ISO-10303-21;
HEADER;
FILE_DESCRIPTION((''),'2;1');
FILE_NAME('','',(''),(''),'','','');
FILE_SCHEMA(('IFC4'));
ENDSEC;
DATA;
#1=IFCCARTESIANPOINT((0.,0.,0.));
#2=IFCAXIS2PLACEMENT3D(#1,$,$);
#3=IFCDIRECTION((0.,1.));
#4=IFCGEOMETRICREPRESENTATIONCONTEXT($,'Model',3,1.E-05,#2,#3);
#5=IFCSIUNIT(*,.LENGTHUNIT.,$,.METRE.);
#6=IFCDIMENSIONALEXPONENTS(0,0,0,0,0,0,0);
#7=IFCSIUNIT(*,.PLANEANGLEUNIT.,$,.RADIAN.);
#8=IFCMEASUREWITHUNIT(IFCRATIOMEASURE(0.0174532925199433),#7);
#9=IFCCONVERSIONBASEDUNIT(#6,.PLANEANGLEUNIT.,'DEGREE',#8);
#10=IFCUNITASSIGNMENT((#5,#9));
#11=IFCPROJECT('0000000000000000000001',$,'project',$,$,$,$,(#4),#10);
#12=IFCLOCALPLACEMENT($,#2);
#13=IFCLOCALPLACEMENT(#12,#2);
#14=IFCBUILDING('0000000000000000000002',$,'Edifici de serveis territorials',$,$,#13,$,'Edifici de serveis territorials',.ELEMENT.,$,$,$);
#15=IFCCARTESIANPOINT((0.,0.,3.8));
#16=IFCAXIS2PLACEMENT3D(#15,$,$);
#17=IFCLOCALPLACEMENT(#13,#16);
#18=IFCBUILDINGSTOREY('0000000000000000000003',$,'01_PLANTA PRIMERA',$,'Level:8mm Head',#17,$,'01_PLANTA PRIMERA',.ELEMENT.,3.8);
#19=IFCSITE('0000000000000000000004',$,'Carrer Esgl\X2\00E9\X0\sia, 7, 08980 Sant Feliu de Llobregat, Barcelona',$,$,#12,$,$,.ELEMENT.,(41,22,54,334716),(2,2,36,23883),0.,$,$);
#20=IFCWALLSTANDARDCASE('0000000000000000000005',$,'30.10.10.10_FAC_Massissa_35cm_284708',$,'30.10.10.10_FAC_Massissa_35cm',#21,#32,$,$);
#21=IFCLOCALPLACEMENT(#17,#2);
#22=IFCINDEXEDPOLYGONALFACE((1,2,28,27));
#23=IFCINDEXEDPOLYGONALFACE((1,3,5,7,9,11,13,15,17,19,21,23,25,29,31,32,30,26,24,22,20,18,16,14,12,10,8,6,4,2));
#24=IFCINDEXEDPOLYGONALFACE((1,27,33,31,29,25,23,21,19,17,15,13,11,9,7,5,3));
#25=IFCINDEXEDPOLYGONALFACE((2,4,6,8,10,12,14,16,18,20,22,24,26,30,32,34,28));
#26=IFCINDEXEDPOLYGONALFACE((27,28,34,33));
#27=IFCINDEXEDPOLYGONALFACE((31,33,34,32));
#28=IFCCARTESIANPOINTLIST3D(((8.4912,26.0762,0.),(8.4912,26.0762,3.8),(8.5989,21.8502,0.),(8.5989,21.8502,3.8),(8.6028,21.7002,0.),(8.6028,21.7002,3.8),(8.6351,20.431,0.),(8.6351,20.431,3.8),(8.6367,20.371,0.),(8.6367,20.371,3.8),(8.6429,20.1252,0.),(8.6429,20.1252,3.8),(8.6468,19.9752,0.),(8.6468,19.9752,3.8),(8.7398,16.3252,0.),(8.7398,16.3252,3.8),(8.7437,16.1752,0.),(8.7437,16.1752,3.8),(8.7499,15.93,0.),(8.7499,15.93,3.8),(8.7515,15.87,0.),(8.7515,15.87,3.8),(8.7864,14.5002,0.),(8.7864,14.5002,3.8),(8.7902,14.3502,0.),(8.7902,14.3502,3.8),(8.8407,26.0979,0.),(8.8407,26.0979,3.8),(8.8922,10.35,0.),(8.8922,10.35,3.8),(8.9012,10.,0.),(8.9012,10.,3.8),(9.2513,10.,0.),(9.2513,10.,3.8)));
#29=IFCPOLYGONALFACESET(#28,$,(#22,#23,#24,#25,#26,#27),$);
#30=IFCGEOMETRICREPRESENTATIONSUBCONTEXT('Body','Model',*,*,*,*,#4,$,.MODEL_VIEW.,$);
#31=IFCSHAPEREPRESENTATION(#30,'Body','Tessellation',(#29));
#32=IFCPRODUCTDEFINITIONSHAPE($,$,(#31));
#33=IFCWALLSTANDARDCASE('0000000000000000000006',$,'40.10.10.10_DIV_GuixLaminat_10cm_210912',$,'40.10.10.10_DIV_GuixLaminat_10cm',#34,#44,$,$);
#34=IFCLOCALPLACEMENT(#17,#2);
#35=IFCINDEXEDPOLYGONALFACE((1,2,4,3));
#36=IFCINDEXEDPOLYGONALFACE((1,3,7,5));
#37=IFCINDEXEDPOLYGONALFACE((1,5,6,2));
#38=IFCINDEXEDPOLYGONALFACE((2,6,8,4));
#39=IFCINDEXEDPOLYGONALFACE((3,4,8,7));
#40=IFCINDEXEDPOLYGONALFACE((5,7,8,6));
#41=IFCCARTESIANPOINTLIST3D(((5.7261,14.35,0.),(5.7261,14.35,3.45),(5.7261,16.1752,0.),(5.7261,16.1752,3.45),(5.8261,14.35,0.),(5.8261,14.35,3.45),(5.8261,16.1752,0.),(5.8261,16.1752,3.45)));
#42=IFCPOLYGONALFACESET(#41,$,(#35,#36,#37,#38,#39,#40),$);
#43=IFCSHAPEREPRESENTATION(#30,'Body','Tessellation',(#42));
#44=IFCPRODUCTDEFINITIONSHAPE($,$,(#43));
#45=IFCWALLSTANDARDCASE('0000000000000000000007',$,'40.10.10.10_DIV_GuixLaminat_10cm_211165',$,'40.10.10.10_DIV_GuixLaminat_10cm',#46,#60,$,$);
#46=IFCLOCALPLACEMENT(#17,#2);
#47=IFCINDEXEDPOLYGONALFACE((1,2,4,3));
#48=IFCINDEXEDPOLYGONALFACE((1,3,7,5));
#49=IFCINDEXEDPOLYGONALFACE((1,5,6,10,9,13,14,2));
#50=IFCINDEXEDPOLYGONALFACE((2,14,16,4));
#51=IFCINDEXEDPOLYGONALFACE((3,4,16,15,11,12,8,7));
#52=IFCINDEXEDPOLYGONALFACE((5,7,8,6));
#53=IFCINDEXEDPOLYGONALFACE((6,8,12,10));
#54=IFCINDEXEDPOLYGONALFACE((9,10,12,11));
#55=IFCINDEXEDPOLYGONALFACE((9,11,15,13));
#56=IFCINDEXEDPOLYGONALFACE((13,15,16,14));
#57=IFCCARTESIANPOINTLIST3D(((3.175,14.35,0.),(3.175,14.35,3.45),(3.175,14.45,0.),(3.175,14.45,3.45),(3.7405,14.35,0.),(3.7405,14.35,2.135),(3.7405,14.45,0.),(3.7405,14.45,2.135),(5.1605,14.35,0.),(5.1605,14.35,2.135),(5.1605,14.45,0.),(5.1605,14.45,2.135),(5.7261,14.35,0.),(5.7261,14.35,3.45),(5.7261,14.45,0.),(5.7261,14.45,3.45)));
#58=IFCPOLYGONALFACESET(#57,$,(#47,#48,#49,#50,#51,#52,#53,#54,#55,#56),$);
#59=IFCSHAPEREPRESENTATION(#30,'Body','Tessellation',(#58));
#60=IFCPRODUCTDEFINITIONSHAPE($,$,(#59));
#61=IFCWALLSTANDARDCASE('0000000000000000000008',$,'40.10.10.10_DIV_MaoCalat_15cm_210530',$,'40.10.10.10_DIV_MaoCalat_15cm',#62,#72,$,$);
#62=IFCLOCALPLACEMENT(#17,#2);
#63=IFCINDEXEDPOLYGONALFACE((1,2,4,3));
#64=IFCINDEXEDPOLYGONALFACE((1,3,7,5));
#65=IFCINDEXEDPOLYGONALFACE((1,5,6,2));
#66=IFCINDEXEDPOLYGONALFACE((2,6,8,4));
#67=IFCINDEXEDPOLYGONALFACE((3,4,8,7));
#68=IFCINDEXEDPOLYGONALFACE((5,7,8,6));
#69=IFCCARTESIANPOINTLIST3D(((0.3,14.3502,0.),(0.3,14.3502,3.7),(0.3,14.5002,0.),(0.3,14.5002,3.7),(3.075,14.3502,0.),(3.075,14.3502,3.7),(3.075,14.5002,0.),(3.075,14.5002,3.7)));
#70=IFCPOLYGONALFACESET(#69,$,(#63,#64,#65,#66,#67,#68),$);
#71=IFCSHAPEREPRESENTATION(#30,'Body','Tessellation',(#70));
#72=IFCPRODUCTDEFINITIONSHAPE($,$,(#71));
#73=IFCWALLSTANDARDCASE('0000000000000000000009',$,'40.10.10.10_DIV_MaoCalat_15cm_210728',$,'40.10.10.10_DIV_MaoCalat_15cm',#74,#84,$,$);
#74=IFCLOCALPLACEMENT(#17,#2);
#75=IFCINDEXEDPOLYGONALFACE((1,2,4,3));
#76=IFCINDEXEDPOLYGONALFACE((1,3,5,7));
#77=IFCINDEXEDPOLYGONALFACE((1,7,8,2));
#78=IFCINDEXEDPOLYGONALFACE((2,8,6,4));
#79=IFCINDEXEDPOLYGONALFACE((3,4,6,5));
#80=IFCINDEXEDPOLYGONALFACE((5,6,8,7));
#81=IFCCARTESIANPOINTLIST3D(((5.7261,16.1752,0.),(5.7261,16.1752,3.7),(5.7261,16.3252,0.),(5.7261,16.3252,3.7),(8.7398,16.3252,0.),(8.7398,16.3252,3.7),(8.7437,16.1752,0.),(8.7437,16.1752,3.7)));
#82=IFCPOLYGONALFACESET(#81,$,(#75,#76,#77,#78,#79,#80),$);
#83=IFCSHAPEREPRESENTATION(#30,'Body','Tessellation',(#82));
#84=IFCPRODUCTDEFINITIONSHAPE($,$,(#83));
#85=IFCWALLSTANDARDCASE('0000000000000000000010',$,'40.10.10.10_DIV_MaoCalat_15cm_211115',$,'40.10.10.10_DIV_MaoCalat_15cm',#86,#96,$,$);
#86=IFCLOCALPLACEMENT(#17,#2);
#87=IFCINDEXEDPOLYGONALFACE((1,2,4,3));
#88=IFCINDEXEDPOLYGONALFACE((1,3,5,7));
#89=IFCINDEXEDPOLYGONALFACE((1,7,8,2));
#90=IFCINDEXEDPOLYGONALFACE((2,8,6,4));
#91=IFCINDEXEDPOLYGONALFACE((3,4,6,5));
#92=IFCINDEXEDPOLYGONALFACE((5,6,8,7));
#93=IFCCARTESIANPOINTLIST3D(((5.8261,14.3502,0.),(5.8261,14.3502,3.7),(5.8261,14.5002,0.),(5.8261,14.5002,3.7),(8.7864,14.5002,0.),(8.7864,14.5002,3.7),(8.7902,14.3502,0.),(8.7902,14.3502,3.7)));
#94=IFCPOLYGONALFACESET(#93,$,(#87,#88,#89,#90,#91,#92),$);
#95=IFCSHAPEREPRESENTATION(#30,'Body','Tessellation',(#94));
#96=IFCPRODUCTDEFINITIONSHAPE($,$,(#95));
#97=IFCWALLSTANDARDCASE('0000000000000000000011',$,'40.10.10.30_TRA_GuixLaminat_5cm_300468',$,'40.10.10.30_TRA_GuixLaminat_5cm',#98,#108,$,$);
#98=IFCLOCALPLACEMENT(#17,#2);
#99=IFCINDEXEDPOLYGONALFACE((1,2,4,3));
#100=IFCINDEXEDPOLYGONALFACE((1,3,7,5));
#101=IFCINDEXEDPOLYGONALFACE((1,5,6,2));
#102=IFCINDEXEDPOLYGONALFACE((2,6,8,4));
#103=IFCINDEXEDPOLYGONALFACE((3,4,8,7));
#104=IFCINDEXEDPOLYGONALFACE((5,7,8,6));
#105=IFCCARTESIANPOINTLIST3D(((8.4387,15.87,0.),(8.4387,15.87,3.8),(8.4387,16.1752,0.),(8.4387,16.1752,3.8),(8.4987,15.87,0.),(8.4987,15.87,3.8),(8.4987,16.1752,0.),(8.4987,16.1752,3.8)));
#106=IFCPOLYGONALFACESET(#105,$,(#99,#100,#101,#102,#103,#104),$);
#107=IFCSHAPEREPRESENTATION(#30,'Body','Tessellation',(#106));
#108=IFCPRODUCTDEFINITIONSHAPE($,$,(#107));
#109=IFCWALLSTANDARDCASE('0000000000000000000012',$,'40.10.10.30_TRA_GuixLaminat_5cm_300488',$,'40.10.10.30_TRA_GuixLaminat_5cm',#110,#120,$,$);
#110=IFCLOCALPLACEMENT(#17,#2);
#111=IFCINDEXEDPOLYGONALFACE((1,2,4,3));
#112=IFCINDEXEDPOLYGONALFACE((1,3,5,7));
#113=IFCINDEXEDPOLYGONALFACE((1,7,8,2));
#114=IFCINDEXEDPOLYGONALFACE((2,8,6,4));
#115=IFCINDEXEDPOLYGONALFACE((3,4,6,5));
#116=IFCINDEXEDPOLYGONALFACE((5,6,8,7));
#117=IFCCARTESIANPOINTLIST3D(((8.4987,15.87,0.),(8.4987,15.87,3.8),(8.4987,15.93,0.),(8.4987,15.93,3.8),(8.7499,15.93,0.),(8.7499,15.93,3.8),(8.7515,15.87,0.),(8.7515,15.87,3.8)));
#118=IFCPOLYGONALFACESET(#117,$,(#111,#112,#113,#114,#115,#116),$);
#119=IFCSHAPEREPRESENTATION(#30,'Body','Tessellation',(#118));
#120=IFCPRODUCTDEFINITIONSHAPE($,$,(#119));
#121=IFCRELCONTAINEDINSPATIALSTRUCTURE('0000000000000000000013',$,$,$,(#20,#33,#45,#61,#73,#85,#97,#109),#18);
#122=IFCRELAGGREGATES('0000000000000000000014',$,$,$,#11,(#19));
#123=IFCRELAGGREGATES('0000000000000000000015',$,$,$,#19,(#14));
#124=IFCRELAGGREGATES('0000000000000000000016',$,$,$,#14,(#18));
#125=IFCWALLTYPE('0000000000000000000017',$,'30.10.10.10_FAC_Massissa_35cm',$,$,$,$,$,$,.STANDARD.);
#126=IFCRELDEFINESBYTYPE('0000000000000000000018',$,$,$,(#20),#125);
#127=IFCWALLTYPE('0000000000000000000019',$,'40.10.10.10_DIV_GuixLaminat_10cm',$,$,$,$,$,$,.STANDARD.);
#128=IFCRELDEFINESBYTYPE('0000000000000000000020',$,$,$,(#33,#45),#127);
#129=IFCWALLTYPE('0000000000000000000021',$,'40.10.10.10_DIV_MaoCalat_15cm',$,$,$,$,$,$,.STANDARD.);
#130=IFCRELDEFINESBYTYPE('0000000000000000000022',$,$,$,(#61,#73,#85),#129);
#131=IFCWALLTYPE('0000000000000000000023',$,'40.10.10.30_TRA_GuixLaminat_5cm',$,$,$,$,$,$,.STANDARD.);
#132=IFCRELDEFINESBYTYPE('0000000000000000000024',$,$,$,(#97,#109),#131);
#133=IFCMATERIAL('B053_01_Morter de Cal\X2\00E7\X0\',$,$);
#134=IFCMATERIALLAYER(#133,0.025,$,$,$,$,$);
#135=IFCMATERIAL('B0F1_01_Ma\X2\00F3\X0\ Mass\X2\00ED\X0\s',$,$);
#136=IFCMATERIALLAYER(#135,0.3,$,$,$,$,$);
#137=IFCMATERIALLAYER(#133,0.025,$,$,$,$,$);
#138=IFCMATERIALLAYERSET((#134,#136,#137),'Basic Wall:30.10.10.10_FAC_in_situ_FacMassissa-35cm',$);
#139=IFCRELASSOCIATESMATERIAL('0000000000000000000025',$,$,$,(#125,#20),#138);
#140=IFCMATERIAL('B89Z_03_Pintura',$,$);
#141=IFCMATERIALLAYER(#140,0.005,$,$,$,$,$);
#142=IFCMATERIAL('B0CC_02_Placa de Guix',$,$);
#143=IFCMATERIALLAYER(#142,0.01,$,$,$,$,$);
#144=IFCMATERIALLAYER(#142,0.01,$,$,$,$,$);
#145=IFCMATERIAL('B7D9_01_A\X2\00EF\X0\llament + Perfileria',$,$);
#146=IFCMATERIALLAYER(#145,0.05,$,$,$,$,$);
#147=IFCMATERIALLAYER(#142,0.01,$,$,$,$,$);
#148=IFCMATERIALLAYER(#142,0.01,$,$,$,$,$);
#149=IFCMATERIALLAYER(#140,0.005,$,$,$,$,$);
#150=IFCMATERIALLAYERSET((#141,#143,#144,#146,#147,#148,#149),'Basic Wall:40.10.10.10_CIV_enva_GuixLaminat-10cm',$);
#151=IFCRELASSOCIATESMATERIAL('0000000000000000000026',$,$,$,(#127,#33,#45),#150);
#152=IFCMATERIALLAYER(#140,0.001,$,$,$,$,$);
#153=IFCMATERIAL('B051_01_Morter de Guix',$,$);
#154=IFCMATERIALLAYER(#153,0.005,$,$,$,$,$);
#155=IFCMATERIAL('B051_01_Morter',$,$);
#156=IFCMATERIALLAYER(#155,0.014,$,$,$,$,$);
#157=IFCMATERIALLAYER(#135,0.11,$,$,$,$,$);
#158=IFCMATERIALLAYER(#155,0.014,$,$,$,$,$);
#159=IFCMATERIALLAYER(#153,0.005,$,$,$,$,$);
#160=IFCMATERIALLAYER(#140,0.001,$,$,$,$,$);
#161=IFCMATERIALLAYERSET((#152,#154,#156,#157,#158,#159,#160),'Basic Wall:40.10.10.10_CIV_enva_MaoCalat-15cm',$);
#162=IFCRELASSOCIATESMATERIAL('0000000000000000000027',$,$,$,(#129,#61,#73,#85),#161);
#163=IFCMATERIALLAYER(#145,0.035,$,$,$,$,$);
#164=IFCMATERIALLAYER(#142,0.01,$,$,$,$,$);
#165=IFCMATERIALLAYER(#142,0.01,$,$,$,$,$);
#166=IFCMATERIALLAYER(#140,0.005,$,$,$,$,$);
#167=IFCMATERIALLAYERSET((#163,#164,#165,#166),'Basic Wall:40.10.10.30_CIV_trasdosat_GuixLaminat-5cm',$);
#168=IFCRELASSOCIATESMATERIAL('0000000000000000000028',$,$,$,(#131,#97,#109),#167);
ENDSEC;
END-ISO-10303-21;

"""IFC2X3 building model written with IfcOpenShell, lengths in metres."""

from ifc_helpers import new_model, entity, si_unit, converted_unit, direction, frame, frame_2d, origin, place, context, subcontext, project, spatial, polyline, rectangle, outline, extrude, clip, bounded_halfspace, material, layer, layer_set, layer_usage, type_object, element, save


model = new_model("IFC2X3")

# Units and contexts
model_context = context("Model", 3, precision=1e-05, world=origin(), true_north=direction((0.0, 1.0)))
body_context = subcontext(model_context, "Body", "Model", "MODEL_VIEW")
ifc_project = project(units=[si_unit("LENGTHUNIT", "METRE"), converted_unit("PLANEANGLEUNIT", "DEGREE", entity("IfcRatioMeasure", 0.0174532925199433), si_unit("PLANEANGLEUNIT", "RADIAN"), dimensions=[0, 0, 0, 0, 0, 0, 0])], contexts=[model_context])

# Site, building, storey
site_placement = place(None, origin())
site = spatial("IfcSite", under=ifc_project, at=site_placement, Name="Carrer Església, 7, 08980 Sant Feliu de Llobregat, Barcelona", CompositionType="ELEMENT", RefLatitude=(41, 22, 54, 334716), RefLongitude=(2, 2, 36, 23883), RefElevation=0.0)
building_placement = place(site_placement, origin())
building = spatial("IfcBuilding", under=site, at=building_placement, Name="Edifici de serveis territorials", LongName="Edifici de serveis territorials", CompositionType="ELEMENT")
storey_placement = place(building_placement, frame((0.0, 0.0, 3.8)))
storey = spatial("IfcBuildingStorey", under=building, at=storey_placement, Name="01_PLANTA PRIMERA", ObjectType="Level:8mm Head", LongName="01_PLANTA PRIMERA", CompositionType="ELEMENT", Elevation=3.8)

# Shared definitions
ifc_material_1 = material(Name="B051_01_Morter")

# Wall
ifc_material_2 = material(Name="B053_01_Morter de Calç")
ifc_layer_1 = layer(ifc_material_2, 0.025)
ifc_material_3 = material(Name="B0F1_01_Maó Massís")
ifc_layer_2 = layer(ifc_material_3, 0.3)
ifc_layer_3 = layer(ifc_material_2, 0.025)
ifc_layer_set_1 = layer_set([ifc_layer_1, ifc_layer_2, ifc_layer_3], Name="Basic Wall:30.10.10.10_FAC_in_situ_FacMassissa-35cm")
ifc_layer_usage_1 = layer_usage(ifc_layer_set_1, "AXIS2", "POSITIVE", -0.175)
wall_type_1 = type_object("IfcWallType", Name="30.10.10.10_FAC_Massissa_35cm", PredefinedType="STANDARD", material=ifc_layer_set_1)
wall_1_placement = place(storey_placement, frame((9.0763, 9.9955, 0.0), z_axis=(0.0, 0.0, 1.0), x_axis=(-0.025497, 0.999675, 0.0)))
element("IfcWallStandardCase", 1, at=wall_1_placement, inside=storey, type_object=wall_type_1, material=ifc_layer_usage_1, Name="30.10.10.10_FAC_Massissa_35cm_284708", ObjectType="30.10.10.10_FAC_Massissa_35cm", context=body_context, shape_type="SweptSolid", body=[
    extrude(outline(polyline([(16.1031, -0.175), (16.0904, 0.175), (11.863, 0.175), (11.7129, 0.175), (10.4433, 0.175), (10.3833, 0.175), (10.1374, 0.175), (9.9874, 0.175), (6.3362, 0.175), (6.1861, 0.175), (5.9409, 0.175), (5.8808, 0.175), (4.5106, 0.175), (4.3605, 0.175), (0.359, 0.175), (0.0089, 0.175), (0.0, -0.175), (16.1031, -0.175)])), origin(), (0.0, 0.0, 1.0), 3.8),
])

# Walls, openings
ifc_material_4 = material(Name="B89Z_03_Pintura")
ifc_layer_4 = layer(ifc_material_4, 0.005)
ifc_material_5 = material(Name="B0CC_02_Placa de Guix")
ifc_layer_5 = layer(ifc_material_5, 0.01)
ifc_layer_6 = layer(ifc_material_5, 0.01)
ifc_material_6 = material(Name="B7D9_01_Aïllament + Perfileria")
ifc_layer_7 = layer(ifc_material_6, 0.05)
ifc_layer_8 = layer(ifc_material_5, 0.01)
ifc_layer_9 = layer(ifc_material_5, 0.01)
ifc_layer_10 = layer(ifc_material_4, 0.005)
ifc_layer_set_2 = layer_set([ifc_layer_4, ifc_layer_5, ifc_layer_6, ifc_layer_7, ifc_layer_8, ifc_layer_9, ifc_layer_10], Name="Basic Wall:40.10.10.10_CIV_enva_GuixLaminat-10cm")
ifc_layer_usage_2 = layer_usage(ifc_layer_set_2, "AXIS2", "NEGATIVE", 0.05)
wall_type_2 = type_object("IfcWallType", Name="40.10.10.10_DIV_GuixLaminat_10cm", PredefinedType="STANDARD", material=ifc_layer_set_2)
wall_2_placement = place(storey_placement, frame((5.7761, 16.1752, 0.0), z_axis=(0.0, 0.0, 1.0), x_axis=(0.0, -1.0, 0.0)))
wall_2 = element("IfcWallStandardCase", 2, at=wall_2_placement, inside=storey, type_object=wall_type_2, material=ifc_layer_usage_2, Name="40.10.10.10_DIV_GuixLaminat_10cm_210912", ObjectType="40.10.10.10_DIV_GuixLaminat_10cm", context=body_context, shape_type="Clipping", body=[
    clip(extrude(rectangle(XDim=1.8252, YDim=0.1, at=frame_2d((0.9126, 0.0), x_axis=(-1.0, 0.0))), origin(), (0.0, 0.0, 1.0), 3.45), bounded_halfspace(frame((0.0, -0.05, 3.45), z_axis=(0.0, 0.0, -1.0), x_axis=(0.999675, 0.025497, 0.0)), True, frame((0.0, -0.05, 3.45)), polyline([(0.0, 0.0), (1.7252, 0.0), (1.8252, 0.0), (1.8252, 0.1), (0.0, 0.1), (0.0, 0.0)]))),
])
opening_1_placement = place(wall_2_placement, frame((1.5252, -0.05, 0.0)))
element("IfcOpeningElement", 3, at=opening_1_placement, cuts=wall_2, ObjectType="Opening", context=body_context, shape_type="SweptSolid", body=[
    extrude(rectangle(XDim=2.1, YDim=0.8, at=frame_2d((1.05, 0.4), x_axis=(1.0, 0.0))), frame((0.0, 0.0, 0.0), z_axis=(0.0, -1.0, 0.0), x_axis=(0.0, 0.0, 1.0)), (0.0, 0.0, 1.0), 0.1),
])
ifc_layer_usage_3 = layer_usage(ifc_layer_set_2, "AXIS2", "POSITIVE", -0.05)
wall_3_placement = place(storey_placement, frame((3.175, 14.4, 0.0)))
wall_3 = element("IfcWallStandardCase", 4, at=wall_3_placement, inside=storey, type_object=wall_type_2, material=ifc_layer_usage_3, Name="40.10.10.10_DIV_GuixLaminat_10cm_211165", ObjectType="40.10.10.10_DIV_GuixLaminat_10cm", context=body_context, shape_type="Clipping", body=[
    clip(extrude(rectangle(XDim=2.5511, YDim=0.1, at=frame_2d((1.2755, 0.0), x_axis=(-1.0, 0.0))), origin(), (0.0, 0.0, 1.0), 3.45), bounded_halfspace(frame((0.0, -0.05, 3.45), z_axis=(0.0, 0.0, -1.0), x_axis=(0.025497, -0.999675, 0.0)), True, frame((0.0, -0.05, 3.45)), polyline([(0.0, 0.0), (2.5511, 0.0), (2.5511, 0.1), (0.0, 0.1), (0.0, 0.0)]))),
])
opening_2_placement = place(wall_3_placement, frame((0.5655, -0.05, 0.0)))
element("IfcOpeningElement", 5, at=opening_2_placement, cuts=wall_3, ObjectType="Opening", context=body_context, shape_type="SweptSolid", body=[
    extrude(rectangle(XDim=2.135, YDim=1.42, at=frame_2d((0.0, 0.0), x_axis=(0.0, 1.0))), frame((0.71, 0.0, 1.0675), z_axis=(0.0, 1.0, 0.0), x_axis=(1.0, 0.0, 0.0)), (0.0, 0.0, 1.0), 0.1),
])

# Walls
ifc_layer_11 = layer(ifc_material_4, 0.001)
ifc_material_7 = material(Name="B051_01_Morter de Guix")
ifc_layer_12 = layer(ifc_material_7, 0.005)
ifc_layer_13 = layer(ifc_material_1, 0.014)
ifc_layer_14 = layer(ifc_material_3, 0.11)
ifc_layer_15 = layer(ifc_material_1, 0.014)
ifc_layer_16 = layer(ifc_material_7, 0.005)
ifc_layer_17 = layer(ifc_material_4, 0.001)
ifc_layer_set_3 = layer_set([ifc_layer_11, ifc_layer_12, ifc_layer_13, ifc_layer_14, ifc_layer_15, ifc_layer_16, ifc_layer_17], Name="Basic Wall:40.10.10.10_CIV_enva_MaoCalat-15cm")
ifc_layer_usage_4 = layer_usage(ifc_layer_set_3, "AXIS2", "NEGATIVE", 0.075)
wall_type_3 = type_object("IfcWallType", Name="40.10.10.10_DIV_MaoCalat_15cm", PredefinedType="STANDARD", material=ifc_layer_set_3)
wall_4_placement = place(storey_placement, frame((3.075, 14.4252, 0.0), z_axis=(0.0, 0.0, 1.0), x_axis=(-1.0, 0.0, 0.0)))
element("IfcWallStandardCase", 6, at=wall_4_placement, inside=storey, type_object=wall_type_3, material=ifc_layer_usage_4, Name="40.10.10.10_DIV_MaoCalat_15cm_210530", ObjectType="40.10.10.10_DIV_MaoCalat_15cm", context=body_context, shape_type="Clipping", body=[
    clip(extrude(rectangle(XDim=2.775, YDim=0.15, at=frame_2d((1.3875, 0.0), x_axis=(-1.0, 0.0))), origin(), (0.0, 0.0, 1.0), 3.7), bounded_halfspace(frame((0.0, -0.075, 3.7), z_axis=(0.0, 0.0, -1.0), x_axis=(0.0, -1.0, 0.0)), True, frame((0.0, -0.075, 3.7)), polyline([(0.0, 0.0), (2.775, 0.0), (2.775, 0.15), (0.0, 0.15), (0.0, 0.0)]))),
])
ifc_layer_usage_5 = layer_usage(ifc_layer_set_3, "AXIS2", "NEGATIVE", 0.075)
wall_5_placement = place(storey_placement, frame((8.7437, 16.2502, 0.0), z_axis=(0.0, 0.0, 1.0), x_axis=(-1.0, 0.0, 0.0)))
element("IfcWallStandardCase", 7, at=wall_5_placement, inside=storey, type_object=wall_type_3, material=ifc_layer_usage_5, Name="40.10.10.10_DIV_MaoCalat_15cm_210728", ObjectType="40.10.10.10_DIV_MaoCalat_15cm", context=body_context, shape_type="Clipping", body=[
    clip(extrude(outline(polyline([(3.0176, -0.075), (3.0176, 0.075), (2.9176, 0.075), (0.305, 0.075), (0.245, 0.075), (0.0, 0.075), (0.0038, -0.075), (3.0176, -0.075)])), origin(), (0.0, 0.0, 1.0), 3.7), bounded_halfspace(frame((0.0038, -0.075, 3.7), z_axis=(0.0, 0.0, -1.0), x_axis=(0.0, -1.0, 0.0)), True, frame((0.0038, -0.075, 3.7)), polyline([(0.0, 0.0), (2.9888, 0.0), (3.0138, 0.0), (3.0138, 0.15), (-0.0038, 0.15), (0.0, 0.0)]))),
])
ifc_layer_usage_6 = layer_usage(ifc_layer_set_3, "AXIS2", "NEGATIVE", 0.075)
wall_6_placement = place(storey_placement, frame((5.8261, 14.4252, 0.0)))
element("IfcWallStandardCase", 8, at=wall_6_placement, inside=storey, type_object=wall_type_3, material=ifc_layer_usage_6, Name="40.10.10.10_DIV_MaoCalat_15cm_211115", ObjectType="40.10.10.10_DIV_MaoCalat_15cm", context=body_context, shape_type="Clipping", body=[
    clip(extrude(outline(polyline([(2.9641, -0.075), (2.9603, 0.075), (0.0, 0.075), (0.0, -0.075), (2.9641, -0.075)])), origin(), (0.0, 0.0, 1.0), 3.7), bounded_halfspace(frame((0.0, -0.075, 3.7), z_axis=(0.0, 0.0, -1.0), x_axis=(0.0, 1.0, 0.0)), True, frame((0.0, -0.075, 3.7)), polyline([(0.0, 0.0), (2.9641, 0.0), (2.9603, 0.15), (0.0, 0.15), (0.0, 0.0)]))),
])
ifc_layer_18 = layer(ifc_material_6, 0.035)
ifc_layer_19 = layer(ifc_material_5, 0.01)
ifc_layer_20 = layer(ifc_material_5, 0.01)
ifc_layer_21 = layer(ifc_material_4, 0.005)
ifc_layer_set_4 = layer_set([ifc_layer_18, ifc_layer_19, ifc_layer_20, ifc_layer_21], Name="Basic Wall:40.10.10.30_CIV_trasdosat_GuixLaminat-5cm")
ifc_layer_usage_7 = layer_usage(ifc_layer_set_4, "AXIS2", "NEGATIVE", 0.03)
wall_type_4 = type_object("IfcWallType", Name="40.10.10.30_TRA_GuixLaminat_5cm", PredefinedType="STANDARD", material=ifc_layer_set_4)
wall_7_placement = place(storey_placement, frame((8.4687, 16.1752, 0.0), z_axis=(0.0, 0.0, 1.0), x_axis=(0.0, -1.0, 0.0)))
element("IfcWallStandardCase", 9, at=wall_7_placement, inside=storey, type_object=wall_type_4, material=ifc_layer_usage_7, Name="40.10.10.30_TRA_GuixLaminat_5cm_300468", ObjectType="40.10.10.30_TRA_GuixLaminat_5cm", context=body_context, shape_type="SweptSolid", body=[
    extrude(rectangle(XDim=0.3052, YDim=0.06, at=frame_2d((0.1526, 0.0), x_axis=(-1.0, 0.0))), origin(), (0.0, 0.0, 1.0), 3.8),
])
ifc_layer_usage_8 = layer_usage(ifc_layer_set_4, "AXIS2", "NEGATIVE", 0.03)
wall_8_placement = place(storey_placement, frame((8.4987, 15.9, 0.0)))
element("IfcWallStandardCase", 10, at=wall_8_placement, inside=storey, type_object=wall_type_4, material=ifc_layer_usage_8, Name="40.10.10.30_TRA_GuixLaminat_5cm_300488", ObjectType="40.10.10.30_TRA_GuixLaminat_5cm", context=body_context, shape_type="SweptSolid", body=[
    extrude(outline(polyline([(0.2528, -0.03), (0.2513, 0.03), (0.0, 0.03), (0.0, -0.03), (0.2528, -0.03)])), origin(), (0.0, 0.0, 1.0), 3.8),
])

save(model, "model.ifc")
